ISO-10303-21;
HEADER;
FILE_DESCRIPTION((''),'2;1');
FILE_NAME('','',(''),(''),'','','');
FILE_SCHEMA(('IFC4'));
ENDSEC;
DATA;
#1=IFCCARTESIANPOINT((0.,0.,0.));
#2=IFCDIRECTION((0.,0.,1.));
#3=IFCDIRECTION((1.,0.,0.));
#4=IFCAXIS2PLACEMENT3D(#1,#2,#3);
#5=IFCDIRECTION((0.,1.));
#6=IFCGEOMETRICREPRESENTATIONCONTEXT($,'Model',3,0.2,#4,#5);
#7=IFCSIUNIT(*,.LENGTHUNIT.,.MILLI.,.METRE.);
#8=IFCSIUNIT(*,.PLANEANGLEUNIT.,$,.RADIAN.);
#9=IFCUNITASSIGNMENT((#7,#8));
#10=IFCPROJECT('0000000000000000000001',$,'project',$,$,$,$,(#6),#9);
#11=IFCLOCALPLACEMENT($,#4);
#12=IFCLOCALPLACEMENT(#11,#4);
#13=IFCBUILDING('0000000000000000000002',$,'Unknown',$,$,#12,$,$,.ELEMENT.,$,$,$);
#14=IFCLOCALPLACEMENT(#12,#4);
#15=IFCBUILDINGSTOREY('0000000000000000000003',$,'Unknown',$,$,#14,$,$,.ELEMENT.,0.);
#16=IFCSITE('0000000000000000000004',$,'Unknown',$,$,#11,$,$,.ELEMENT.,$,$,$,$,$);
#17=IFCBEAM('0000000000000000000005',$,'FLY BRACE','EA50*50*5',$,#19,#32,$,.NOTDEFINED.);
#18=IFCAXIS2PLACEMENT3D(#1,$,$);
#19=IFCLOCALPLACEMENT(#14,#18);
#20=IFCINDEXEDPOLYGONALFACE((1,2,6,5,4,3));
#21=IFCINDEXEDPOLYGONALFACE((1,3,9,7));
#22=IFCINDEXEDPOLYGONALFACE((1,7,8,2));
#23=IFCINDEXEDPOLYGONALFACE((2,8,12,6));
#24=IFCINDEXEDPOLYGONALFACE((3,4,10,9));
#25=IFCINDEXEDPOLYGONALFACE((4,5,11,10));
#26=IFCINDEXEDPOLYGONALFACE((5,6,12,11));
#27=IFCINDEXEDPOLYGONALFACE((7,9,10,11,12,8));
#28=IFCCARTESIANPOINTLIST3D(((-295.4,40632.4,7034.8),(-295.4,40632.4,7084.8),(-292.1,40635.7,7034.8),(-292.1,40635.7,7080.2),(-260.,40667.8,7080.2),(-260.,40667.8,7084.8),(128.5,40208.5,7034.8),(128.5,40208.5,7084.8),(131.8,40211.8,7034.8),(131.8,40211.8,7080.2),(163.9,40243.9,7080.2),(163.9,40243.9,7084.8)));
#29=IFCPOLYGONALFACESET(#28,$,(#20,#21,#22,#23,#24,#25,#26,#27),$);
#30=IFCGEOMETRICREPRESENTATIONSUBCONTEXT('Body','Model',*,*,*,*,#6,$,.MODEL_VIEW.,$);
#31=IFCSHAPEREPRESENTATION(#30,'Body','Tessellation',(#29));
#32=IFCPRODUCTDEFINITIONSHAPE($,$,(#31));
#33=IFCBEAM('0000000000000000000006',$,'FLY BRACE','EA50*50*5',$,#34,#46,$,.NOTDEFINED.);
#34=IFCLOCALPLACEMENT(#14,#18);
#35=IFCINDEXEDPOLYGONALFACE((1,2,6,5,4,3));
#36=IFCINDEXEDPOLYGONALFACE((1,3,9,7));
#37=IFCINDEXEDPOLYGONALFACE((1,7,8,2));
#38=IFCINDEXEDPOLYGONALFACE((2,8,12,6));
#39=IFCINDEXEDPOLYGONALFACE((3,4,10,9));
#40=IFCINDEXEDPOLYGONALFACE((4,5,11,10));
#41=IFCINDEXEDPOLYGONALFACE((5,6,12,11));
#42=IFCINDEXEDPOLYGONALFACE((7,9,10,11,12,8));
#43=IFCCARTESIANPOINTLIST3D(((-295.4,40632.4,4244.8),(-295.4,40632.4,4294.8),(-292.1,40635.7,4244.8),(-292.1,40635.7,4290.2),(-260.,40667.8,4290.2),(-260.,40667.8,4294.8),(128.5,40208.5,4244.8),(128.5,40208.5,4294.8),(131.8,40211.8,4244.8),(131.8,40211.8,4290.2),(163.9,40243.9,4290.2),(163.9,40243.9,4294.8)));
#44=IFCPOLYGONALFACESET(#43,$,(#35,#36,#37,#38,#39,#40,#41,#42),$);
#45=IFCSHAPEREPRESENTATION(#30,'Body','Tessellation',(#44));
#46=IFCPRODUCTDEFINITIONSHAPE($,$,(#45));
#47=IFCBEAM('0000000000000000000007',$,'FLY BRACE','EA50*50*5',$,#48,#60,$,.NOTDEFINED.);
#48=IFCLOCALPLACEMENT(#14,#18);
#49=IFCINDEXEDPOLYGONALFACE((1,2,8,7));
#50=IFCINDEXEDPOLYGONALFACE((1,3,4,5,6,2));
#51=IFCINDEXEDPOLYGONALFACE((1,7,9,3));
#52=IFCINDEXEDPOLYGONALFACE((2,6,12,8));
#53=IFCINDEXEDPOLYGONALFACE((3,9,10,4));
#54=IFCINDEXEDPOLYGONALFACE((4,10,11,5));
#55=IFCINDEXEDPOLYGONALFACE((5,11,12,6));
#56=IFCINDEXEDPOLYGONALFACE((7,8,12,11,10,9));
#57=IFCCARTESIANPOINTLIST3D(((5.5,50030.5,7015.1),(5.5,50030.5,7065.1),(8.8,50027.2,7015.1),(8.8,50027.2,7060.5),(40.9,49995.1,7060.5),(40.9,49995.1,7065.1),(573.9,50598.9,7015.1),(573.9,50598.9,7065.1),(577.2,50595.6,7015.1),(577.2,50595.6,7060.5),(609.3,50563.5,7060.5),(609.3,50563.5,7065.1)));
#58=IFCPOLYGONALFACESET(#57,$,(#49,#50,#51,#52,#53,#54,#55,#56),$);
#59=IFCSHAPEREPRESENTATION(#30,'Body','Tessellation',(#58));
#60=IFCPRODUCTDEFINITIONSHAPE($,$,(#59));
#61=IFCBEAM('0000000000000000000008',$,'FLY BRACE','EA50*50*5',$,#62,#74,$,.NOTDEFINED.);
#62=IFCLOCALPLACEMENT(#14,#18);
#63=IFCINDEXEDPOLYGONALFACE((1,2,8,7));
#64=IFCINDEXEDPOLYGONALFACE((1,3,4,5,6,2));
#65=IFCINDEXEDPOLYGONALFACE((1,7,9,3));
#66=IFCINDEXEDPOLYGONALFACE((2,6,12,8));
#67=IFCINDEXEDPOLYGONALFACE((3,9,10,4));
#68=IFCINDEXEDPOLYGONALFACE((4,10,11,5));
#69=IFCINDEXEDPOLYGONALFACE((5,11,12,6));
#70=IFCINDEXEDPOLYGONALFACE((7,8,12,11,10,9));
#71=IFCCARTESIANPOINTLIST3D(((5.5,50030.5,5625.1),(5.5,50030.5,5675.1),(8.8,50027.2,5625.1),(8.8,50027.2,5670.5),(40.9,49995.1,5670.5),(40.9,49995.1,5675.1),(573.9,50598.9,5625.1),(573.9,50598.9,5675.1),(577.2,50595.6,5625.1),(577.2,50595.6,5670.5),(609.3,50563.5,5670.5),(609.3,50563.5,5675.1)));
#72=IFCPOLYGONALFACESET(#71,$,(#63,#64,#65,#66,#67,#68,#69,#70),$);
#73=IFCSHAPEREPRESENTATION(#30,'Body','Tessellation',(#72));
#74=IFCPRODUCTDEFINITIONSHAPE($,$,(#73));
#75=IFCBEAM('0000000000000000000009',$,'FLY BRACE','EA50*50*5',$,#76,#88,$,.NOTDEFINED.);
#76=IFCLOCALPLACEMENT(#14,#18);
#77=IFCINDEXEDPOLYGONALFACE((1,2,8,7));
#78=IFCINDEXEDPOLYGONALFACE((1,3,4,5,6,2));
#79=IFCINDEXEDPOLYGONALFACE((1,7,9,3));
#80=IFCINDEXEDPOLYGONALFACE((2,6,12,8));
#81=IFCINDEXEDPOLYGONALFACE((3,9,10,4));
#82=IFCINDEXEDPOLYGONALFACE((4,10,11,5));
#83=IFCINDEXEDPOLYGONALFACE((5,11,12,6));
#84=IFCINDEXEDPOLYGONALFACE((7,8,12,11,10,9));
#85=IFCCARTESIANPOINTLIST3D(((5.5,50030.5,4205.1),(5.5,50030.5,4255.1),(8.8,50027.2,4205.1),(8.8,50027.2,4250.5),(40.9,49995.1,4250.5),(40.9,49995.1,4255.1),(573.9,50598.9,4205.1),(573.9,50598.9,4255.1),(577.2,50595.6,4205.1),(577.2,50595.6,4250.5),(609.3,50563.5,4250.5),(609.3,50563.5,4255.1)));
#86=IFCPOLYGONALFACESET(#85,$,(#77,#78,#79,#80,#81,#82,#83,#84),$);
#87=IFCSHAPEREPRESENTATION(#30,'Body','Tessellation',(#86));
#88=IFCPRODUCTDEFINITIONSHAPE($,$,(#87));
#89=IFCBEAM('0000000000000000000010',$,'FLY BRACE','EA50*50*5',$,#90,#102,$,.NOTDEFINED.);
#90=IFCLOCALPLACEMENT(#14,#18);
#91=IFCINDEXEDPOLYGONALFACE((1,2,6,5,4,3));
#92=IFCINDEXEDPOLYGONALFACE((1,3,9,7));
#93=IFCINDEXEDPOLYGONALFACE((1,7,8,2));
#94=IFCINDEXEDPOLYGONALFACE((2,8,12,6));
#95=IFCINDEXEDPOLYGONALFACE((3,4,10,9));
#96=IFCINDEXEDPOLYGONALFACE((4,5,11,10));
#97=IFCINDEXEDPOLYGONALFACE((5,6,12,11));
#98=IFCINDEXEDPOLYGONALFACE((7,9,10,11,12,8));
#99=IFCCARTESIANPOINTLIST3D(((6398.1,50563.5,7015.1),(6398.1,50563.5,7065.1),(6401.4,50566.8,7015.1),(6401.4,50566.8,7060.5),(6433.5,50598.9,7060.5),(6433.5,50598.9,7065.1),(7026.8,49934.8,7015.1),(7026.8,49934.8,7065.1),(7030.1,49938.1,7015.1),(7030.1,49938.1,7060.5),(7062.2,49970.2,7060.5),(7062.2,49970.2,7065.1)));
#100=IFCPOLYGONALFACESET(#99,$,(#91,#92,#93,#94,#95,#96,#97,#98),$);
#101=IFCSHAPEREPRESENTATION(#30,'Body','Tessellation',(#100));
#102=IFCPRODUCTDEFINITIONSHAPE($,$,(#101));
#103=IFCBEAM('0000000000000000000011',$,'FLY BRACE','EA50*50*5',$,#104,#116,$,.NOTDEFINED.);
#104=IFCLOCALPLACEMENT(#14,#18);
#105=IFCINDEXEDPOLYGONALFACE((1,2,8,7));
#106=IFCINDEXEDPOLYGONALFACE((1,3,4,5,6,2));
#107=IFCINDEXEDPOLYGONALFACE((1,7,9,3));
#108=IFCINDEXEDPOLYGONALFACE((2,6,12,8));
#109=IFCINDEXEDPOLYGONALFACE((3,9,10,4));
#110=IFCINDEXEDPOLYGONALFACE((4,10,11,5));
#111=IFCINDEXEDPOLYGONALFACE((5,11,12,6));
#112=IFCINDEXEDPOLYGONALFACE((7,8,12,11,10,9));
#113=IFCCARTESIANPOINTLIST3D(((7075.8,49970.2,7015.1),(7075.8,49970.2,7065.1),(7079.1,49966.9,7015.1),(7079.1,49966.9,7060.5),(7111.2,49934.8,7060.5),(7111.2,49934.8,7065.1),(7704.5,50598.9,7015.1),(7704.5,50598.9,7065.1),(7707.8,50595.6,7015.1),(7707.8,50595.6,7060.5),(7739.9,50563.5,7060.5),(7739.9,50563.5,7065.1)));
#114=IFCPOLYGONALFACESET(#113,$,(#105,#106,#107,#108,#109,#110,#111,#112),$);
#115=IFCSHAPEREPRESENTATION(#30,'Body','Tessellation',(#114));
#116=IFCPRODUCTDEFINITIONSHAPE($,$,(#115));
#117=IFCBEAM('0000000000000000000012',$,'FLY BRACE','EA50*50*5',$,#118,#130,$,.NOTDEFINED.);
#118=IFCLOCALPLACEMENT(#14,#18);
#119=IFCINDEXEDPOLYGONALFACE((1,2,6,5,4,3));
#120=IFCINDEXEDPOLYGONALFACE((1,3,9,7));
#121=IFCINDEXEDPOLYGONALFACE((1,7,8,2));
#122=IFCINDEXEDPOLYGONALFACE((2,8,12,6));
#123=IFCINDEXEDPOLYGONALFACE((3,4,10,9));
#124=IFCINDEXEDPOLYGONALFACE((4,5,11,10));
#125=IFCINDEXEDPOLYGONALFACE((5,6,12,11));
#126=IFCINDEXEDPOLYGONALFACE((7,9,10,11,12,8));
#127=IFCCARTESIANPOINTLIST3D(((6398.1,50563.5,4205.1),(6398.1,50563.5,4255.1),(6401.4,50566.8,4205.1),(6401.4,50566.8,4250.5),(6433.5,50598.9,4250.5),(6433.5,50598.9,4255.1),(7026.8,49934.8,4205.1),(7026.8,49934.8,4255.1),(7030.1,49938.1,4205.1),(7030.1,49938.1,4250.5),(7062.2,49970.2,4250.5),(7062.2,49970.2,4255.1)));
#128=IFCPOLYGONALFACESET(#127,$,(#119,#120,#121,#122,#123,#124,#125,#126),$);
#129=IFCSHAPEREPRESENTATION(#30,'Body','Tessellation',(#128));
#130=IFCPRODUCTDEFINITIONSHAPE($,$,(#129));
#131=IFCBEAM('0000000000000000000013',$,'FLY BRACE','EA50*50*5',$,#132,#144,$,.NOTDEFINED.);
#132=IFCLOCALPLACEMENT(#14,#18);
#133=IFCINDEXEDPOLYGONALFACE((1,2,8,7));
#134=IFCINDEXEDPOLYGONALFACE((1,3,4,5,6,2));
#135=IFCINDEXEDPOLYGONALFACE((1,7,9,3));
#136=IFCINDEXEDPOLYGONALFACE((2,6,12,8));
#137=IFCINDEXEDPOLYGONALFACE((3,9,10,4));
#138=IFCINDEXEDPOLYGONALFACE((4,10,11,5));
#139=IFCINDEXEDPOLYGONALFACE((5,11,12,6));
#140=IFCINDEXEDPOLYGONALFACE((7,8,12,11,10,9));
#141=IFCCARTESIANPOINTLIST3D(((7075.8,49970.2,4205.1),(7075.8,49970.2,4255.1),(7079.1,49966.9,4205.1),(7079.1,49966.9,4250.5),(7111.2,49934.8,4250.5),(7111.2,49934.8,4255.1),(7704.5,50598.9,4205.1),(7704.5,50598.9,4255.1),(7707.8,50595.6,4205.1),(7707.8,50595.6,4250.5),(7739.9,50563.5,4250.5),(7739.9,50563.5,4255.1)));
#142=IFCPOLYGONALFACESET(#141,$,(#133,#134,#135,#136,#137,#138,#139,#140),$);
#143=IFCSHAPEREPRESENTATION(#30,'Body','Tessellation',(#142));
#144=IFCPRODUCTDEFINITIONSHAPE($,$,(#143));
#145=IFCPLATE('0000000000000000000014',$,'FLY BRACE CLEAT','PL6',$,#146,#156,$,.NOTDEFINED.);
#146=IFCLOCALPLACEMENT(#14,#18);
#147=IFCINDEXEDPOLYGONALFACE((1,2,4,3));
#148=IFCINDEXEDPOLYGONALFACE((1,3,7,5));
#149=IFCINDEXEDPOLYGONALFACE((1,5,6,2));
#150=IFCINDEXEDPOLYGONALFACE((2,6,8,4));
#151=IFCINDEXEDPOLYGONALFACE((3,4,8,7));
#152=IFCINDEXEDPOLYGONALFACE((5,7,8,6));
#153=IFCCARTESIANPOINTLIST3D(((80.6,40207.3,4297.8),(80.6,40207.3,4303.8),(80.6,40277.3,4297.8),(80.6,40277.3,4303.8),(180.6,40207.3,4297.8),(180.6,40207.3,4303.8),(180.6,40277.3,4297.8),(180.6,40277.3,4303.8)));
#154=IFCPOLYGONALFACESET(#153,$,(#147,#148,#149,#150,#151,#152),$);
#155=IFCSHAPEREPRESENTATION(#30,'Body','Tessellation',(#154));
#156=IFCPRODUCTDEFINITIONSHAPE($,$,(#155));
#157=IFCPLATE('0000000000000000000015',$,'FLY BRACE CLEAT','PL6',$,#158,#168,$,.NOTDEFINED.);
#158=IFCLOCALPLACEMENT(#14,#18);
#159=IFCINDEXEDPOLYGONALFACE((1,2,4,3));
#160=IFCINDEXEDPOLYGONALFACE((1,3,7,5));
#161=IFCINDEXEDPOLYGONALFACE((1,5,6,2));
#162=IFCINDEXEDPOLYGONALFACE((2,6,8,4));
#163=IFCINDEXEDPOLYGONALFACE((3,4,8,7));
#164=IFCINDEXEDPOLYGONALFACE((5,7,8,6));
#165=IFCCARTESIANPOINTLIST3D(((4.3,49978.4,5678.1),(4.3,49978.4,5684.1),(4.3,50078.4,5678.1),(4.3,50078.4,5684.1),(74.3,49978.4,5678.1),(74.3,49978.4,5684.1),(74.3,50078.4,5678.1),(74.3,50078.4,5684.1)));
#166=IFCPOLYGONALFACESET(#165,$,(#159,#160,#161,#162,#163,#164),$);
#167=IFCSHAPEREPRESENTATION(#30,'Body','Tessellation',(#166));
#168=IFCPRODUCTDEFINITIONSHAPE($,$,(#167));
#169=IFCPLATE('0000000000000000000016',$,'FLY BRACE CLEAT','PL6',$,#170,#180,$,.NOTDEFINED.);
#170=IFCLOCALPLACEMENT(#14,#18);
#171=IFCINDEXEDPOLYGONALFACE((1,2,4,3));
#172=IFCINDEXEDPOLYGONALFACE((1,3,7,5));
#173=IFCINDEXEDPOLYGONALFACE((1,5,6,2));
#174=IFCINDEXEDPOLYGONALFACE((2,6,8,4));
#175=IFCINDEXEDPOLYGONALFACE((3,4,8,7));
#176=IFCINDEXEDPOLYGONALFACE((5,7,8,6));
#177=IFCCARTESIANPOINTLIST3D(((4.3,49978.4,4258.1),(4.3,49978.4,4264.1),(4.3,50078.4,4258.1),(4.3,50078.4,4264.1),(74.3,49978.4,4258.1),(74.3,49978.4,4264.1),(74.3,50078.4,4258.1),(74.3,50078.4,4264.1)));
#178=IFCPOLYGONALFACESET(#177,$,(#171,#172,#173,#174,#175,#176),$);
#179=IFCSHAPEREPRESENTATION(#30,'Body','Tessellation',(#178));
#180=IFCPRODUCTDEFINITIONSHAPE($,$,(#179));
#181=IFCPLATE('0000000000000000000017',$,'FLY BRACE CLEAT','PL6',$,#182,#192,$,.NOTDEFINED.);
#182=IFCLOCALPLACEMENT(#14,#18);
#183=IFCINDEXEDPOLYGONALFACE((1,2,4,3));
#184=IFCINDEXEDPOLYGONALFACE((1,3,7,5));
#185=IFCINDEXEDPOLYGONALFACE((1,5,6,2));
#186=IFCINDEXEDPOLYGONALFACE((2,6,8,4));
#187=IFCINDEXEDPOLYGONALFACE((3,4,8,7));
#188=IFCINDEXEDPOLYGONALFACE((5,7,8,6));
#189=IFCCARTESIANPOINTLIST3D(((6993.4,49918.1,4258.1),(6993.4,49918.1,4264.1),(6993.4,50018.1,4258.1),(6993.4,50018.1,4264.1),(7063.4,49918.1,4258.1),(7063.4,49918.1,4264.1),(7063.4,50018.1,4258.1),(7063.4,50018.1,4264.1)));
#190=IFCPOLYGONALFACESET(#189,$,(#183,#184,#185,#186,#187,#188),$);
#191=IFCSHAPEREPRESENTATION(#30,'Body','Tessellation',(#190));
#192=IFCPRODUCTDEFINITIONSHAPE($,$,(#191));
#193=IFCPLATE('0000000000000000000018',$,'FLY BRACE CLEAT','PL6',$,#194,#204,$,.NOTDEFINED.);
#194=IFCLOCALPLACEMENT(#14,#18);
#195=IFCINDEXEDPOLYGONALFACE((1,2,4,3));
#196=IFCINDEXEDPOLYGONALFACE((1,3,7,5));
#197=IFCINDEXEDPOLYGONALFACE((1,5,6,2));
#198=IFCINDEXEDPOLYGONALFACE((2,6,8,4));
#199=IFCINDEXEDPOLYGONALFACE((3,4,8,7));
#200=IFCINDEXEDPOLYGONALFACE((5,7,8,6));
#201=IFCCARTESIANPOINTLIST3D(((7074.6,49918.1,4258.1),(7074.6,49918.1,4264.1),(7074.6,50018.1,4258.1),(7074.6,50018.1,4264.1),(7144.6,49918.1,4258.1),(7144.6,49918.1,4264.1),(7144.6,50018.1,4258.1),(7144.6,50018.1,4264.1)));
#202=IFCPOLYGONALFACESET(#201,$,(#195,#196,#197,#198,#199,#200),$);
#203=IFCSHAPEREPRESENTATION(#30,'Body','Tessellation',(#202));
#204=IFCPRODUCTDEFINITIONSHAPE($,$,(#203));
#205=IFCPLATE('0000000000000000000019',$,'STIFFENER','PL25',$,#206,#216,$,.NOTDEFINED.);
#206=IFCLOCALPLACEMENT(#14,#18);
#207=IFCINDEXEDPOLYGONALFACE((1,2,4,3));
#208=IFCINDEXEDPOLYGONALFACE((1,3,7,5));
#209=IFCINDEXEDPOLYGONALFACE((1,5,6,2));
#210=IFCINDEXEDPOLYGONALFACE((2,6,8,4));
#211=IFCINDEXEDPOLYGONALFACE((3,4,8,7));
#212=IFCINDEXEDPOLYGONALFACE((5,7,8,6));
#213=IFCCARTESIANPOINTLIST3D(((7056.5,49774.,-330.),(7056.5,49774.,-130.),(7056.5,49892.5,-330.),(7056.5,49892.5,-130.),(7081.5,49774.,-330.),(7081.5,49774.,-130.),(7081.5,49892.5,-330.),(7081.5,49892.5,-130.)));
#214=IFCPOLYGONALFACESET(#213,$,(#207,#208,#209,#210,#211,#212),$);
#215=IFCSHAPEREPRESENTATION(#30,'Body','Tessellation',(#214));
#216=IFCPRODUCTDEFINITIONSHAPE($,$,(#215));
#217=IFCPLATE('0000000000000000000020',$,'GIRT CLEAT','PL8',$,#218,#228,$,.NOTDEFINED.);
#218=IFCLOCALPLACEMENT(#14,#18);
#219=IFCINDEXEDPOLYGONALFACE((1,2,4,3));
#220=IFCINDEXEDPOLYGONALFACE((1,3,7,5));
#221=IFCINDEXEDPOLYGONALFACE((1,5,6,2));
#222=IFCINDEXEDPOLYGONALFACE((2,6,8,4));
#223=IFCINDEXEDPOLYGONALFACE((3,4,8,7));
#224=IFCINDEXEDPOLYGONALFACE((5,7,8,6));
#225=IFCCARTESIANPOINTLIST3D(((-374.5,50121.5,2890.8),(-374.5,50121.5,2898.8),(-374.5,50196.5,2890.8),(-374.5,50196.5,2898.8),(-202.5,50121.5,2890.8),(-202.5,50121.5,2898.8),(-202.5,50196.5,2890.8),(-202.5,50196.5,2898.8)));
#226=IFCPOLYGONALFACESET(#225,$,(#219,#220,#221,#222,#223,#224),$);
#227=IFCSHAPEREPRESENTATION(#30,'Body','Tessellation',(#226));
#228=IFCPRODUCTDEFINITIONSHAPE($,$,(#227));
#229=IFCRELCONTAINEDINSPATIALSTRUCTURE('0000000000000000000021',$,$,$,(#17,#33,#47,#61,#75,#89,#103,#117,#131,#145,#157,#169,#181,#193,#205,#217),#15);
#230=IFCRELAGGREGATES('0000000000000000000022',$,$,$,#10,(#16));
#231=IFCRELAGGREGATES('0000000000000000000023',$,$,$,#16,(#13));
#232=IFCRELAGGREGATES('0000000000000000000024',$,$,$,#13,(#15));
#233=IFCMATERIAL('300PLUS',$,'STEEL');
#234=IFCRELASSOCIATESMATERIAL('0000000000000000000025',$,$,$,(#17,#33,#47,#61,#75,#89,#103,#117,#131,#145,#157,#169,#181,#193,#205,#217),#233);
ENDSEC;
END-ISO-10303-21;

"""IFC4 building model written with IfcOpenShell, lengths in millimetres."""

from ifc_helpers import new_model, si_unit, direction, frame, origin_with_axes, place, context, subcontext, project, spatial, line, indexed_curve, outline, extrude, material, element, save


model = new_model("IFC4")

# Units and contexts
model_context = context("Model", 3, precision=0.2, world=origin_with_axes(), true_north=direction((0.0, 1.0)))
body_context = subcontext(model_context, "Body", "Model", "MODEL_VIEW")
ifc_project = project(units=[si_unit("LENGTHUNIT", "METRE", prefix="MILLI"), si_unit("PLANEANGLEUNIT", "RADIAN")], contexts=[model_context])

# Site, building, storey
site_placement = place(None, origin_with_axes())
site = spatial("IfcSite", under=ifc_project, at=site_placement, Name="Unknown", CompositionType="ELEMENT")
building_placement = place(site_placement, origin_with_axes())
building = spatial("IfcBuilding", under=site, at=building_placement, Name="Unknown", CompositionType="ELEMENT")
storey_placement = place(building_placement, origin_with_axes())
storey = spatial("IfcBuildingStorey", under=building, at=storey_placement, Name="Unknown", CompositionType="ELEMENT", Elevation=0.0)

# Shared definitions
ifc_material_1 = material(Name="300PLUS", Category="STEEL")

# Beams
for number, where, z_axis, x_axis, name in (
    (1, (146.2, 40226.2, 7059.8), (0.0, 0.0, -1.0), (-0.707107, 0.707107, 0.0), "FLY BRACE"),
    (2, (146.2, 40226.2, 4269.8), (0.0, 0.0, -1.0), (-0.707107, 0.707107, 0.0), "FLY BRACE"),
):
    element("IfcBeam", number, at=place(storey_placement, frame(where, z_axis=z_axis, x_axis=x_axis)), inside=storey, material=ifc_material_1, Name=name, Description="EA50*50*5", PredefinedType="NOTDEFINED", context=body_context, shape_type="SolidModel", body=[
        extrude(outline(indexed_curve([(-25.0, -25.0), (25.0, -25.0), (25.0, -20.4), (-20.4, -20.4), (-20.4, 25.0), (-25.0, 25.0)], segments=[line(1, 2, 3, 4, 5, 6, 1)])), frame((0.0, 0.0, 0.0), z_axis=(-1.0, 0.0, 0.0), x_axis=(0.0, 0.0, 1.0)), (0.0, 0.0, -1.0), 599.5),
    ])
for number, where, z_axis, x_axis, name in (
    (3, (23.2, 50012.8, 7040.1), (0.0, 0.0, -1.0), (0.707107, 0.707107, 0.0), "FLY BRACE"),
    (4, (23.2, 50012.8, 5650.1), (0.0, 0.0, -1.0), (0.707107, 0.707107, 0.0), "FLY BRACE"),
    (5, (23.2, 50012.8, 4230.1), (0.0, 0.0, -1.0), (0.707107, 0.707107, 0.0), "FLY BRACE"),
):
    element("IfcBeam", number, at=place(storey_placement, frame(where, z_axis=z_axis, x_axis=x_axis)), inside=storey, material=ifc_material_1, Name=name, Description="EA50*50*5", PredefinedType="NOTDEFINED", context=body_context, shape_type="SolidModel", body=[
        extrude(outline(indexed_curve([(-25.0, -25.0), (25.0, -25.0), (25.0, -20.4), (-20.4, -20.4), (-20.4, 25.0), (-25.0, 25.0)], segments=[line(1, 2, 3, 4, 5, 6, 1)])), frame((0.0, 0.0, 0.0), z_axis=(-1.0, 0.0, 0.0), x_axis=(0.0, 0.0, 1.0)), (0.0, 0.0, -1.0), 803.8),
    ])
for number, where, z_axis, x_axis, name in (
    (6, (7044.5, 49952.5, 7040.1), (0.0, 0.0, -1.0), (-0.707107, 0.707107, 0.0), "FLY BRACE"),
    (7, (7093.5, 49952.5, 7040.1), (0.0, 0.0, -1.0), (0.707107, 0.707107, 0.0), "FLY BRACE"),
    (8, (7044.5, 49952.5, 4230.1), (0.0, 0.0, -1.0), (-0.707107, 0.707107, 0.0), "FLY BRACE"),
    (9, (7093.5, 49952.5, 4230.1), (0.0, 0.0, -1.0), (0.707107, 0.707107, 0.0), "FLY BRACE"),
):
    element("IfcBeam", number, at=place(storey_placement, frame(where, z_axis=z_axis, x_axis=x_axis)), inside=storey, material=ifc_material_1, Name=name, Description="EA50*50*5", PredefinedType="NOTDEFINED", context=body_context, shape_type="SolidModel", body=[
        extrude(outline(indexed_curve([(-25.0, -25.0), (25.0, -25.0), (25.0, -20.4), (-20.4, -20.4), (-20.4, 25.0), (-25.0, 25.0)], segments=[line(1, 2, 3, 4, 5, 6, 1)])), frame((0.0, 0.0, 0.0), z_axis=(-1.0, 0.0, 0.0), x_axis=(0.0, 0.0, 1.0)), (0.0, 0.0, -1.0), 889.1),
    ])

# Plates
for number, where, z_axis, x_axis, name in (
    (10, (180.6, 40207.3, 4300.8), (0.0, 0.0, 1.0), (0.0, 1.0, 0.0), "FLY BRACE CLEAT"),
    (11, (74.3, 50078.4, 5681.1), (0.0, 0.0, 1.0), (-1.0, 0.0, 0.0), "FLY BRACE CLEAT"),
    (12, (74.3, 50078.4, 4261.1), (0.0, 0.0, 1.0), (-1.0, 0.0, 0.0), "FLY BRACE CLEAT"),
    (13, (7063.4, 50018.1, 4261.1), (0.0, 0.0, 1.0), (-1.0, 0.0, 0.0), "FLY BRACE CLEAT"),
    (14, (7144.6, 50018.1, 4261.1), (0.0, 0.0, 1.0), (-1.0, 0.0, 0.0), "FLY BRACE CLEAT"),
):
    element("IfcPlate", number, at=place(storey_placement, frame(where, z_axis=z_axis, x_axis=x_axis)), inside=storey, material=ifc_material_1, Name=name, Description="PL6", PredefinedType="NOTDEFINED", context=body_context, shape_type="SolidModel", body=[
        extrude(outline(indexed_curve([(0.0, 0.0), (70.0, 0.0), (70.0, 100.0), (0.0, 100.0)], segments=[line(1, 2, 3, 4, 1)])), frame((0.0, 0.0, 3.0), z_axis=(0.0, 0.0, 1.0), x_axis=(1.0, 0.0, 0.0)), (0.0, 0.0, -1.0), 6.0),
    ])
plate_1_placement = place(storey_placement, frame((7069.0, 49892.5, -130.0), z_axis=(1.0, 0.0, 0.0), x_axis=(0.0, -1.0, 0.0)))
element("IfcPlate", 15, at=plate_1_placement, inside=storey, material=ifc_material_1, Name="STIFFENER", Description="PL25", PredefinedType="NOTDEFINED", context=body_context, shape_type="SolidModel", body=[
    extrude(outline(indexed_curve([(0.0, 0.0), (118.5, 0.0), (118.5, 200.0), (0.0, 200.0)], segments=[line(1, 2, 3, 4, 1)])), frame((0.0, 0.0, 12.5), z_axis=(0.0, 0.0, 1.0), x_axis=(1.0, 0.0, 0.0)), (0.0, 0.0, -1.0), 25.0),
])
plate_2_placement = place(storey_placement, frame((-202.5, 50121.5, 2894.8), z_axis=(0.0, 0.0, 1.0), x_axis=(0.0, 1.0, 0.0)))
element("IfcPlate", 16, at=plate_2_placement, inside=storey, material=ifc_material_1, Name="GIRT CLEAT", Description="PL8", PredefinedType="NOTDEFINED", context=body_context, shape_type="SolidModel", body=[
    extrude(outline(indexed_curve([(0.0, 0.0), (75.0, 0.0), (75.0, 172.0), (0.0, 172.0)], segments=[line(1, 2, 3, 4, 1)])), frame((0.0, 0.0, 4.0), z_axis=(0.0, 0.0, 1.0), x_axis=(1.0, 0.0, 0.0)), (0.0, 0.0, -1.0), 8.0),
])

save(model, "model.ifc")
